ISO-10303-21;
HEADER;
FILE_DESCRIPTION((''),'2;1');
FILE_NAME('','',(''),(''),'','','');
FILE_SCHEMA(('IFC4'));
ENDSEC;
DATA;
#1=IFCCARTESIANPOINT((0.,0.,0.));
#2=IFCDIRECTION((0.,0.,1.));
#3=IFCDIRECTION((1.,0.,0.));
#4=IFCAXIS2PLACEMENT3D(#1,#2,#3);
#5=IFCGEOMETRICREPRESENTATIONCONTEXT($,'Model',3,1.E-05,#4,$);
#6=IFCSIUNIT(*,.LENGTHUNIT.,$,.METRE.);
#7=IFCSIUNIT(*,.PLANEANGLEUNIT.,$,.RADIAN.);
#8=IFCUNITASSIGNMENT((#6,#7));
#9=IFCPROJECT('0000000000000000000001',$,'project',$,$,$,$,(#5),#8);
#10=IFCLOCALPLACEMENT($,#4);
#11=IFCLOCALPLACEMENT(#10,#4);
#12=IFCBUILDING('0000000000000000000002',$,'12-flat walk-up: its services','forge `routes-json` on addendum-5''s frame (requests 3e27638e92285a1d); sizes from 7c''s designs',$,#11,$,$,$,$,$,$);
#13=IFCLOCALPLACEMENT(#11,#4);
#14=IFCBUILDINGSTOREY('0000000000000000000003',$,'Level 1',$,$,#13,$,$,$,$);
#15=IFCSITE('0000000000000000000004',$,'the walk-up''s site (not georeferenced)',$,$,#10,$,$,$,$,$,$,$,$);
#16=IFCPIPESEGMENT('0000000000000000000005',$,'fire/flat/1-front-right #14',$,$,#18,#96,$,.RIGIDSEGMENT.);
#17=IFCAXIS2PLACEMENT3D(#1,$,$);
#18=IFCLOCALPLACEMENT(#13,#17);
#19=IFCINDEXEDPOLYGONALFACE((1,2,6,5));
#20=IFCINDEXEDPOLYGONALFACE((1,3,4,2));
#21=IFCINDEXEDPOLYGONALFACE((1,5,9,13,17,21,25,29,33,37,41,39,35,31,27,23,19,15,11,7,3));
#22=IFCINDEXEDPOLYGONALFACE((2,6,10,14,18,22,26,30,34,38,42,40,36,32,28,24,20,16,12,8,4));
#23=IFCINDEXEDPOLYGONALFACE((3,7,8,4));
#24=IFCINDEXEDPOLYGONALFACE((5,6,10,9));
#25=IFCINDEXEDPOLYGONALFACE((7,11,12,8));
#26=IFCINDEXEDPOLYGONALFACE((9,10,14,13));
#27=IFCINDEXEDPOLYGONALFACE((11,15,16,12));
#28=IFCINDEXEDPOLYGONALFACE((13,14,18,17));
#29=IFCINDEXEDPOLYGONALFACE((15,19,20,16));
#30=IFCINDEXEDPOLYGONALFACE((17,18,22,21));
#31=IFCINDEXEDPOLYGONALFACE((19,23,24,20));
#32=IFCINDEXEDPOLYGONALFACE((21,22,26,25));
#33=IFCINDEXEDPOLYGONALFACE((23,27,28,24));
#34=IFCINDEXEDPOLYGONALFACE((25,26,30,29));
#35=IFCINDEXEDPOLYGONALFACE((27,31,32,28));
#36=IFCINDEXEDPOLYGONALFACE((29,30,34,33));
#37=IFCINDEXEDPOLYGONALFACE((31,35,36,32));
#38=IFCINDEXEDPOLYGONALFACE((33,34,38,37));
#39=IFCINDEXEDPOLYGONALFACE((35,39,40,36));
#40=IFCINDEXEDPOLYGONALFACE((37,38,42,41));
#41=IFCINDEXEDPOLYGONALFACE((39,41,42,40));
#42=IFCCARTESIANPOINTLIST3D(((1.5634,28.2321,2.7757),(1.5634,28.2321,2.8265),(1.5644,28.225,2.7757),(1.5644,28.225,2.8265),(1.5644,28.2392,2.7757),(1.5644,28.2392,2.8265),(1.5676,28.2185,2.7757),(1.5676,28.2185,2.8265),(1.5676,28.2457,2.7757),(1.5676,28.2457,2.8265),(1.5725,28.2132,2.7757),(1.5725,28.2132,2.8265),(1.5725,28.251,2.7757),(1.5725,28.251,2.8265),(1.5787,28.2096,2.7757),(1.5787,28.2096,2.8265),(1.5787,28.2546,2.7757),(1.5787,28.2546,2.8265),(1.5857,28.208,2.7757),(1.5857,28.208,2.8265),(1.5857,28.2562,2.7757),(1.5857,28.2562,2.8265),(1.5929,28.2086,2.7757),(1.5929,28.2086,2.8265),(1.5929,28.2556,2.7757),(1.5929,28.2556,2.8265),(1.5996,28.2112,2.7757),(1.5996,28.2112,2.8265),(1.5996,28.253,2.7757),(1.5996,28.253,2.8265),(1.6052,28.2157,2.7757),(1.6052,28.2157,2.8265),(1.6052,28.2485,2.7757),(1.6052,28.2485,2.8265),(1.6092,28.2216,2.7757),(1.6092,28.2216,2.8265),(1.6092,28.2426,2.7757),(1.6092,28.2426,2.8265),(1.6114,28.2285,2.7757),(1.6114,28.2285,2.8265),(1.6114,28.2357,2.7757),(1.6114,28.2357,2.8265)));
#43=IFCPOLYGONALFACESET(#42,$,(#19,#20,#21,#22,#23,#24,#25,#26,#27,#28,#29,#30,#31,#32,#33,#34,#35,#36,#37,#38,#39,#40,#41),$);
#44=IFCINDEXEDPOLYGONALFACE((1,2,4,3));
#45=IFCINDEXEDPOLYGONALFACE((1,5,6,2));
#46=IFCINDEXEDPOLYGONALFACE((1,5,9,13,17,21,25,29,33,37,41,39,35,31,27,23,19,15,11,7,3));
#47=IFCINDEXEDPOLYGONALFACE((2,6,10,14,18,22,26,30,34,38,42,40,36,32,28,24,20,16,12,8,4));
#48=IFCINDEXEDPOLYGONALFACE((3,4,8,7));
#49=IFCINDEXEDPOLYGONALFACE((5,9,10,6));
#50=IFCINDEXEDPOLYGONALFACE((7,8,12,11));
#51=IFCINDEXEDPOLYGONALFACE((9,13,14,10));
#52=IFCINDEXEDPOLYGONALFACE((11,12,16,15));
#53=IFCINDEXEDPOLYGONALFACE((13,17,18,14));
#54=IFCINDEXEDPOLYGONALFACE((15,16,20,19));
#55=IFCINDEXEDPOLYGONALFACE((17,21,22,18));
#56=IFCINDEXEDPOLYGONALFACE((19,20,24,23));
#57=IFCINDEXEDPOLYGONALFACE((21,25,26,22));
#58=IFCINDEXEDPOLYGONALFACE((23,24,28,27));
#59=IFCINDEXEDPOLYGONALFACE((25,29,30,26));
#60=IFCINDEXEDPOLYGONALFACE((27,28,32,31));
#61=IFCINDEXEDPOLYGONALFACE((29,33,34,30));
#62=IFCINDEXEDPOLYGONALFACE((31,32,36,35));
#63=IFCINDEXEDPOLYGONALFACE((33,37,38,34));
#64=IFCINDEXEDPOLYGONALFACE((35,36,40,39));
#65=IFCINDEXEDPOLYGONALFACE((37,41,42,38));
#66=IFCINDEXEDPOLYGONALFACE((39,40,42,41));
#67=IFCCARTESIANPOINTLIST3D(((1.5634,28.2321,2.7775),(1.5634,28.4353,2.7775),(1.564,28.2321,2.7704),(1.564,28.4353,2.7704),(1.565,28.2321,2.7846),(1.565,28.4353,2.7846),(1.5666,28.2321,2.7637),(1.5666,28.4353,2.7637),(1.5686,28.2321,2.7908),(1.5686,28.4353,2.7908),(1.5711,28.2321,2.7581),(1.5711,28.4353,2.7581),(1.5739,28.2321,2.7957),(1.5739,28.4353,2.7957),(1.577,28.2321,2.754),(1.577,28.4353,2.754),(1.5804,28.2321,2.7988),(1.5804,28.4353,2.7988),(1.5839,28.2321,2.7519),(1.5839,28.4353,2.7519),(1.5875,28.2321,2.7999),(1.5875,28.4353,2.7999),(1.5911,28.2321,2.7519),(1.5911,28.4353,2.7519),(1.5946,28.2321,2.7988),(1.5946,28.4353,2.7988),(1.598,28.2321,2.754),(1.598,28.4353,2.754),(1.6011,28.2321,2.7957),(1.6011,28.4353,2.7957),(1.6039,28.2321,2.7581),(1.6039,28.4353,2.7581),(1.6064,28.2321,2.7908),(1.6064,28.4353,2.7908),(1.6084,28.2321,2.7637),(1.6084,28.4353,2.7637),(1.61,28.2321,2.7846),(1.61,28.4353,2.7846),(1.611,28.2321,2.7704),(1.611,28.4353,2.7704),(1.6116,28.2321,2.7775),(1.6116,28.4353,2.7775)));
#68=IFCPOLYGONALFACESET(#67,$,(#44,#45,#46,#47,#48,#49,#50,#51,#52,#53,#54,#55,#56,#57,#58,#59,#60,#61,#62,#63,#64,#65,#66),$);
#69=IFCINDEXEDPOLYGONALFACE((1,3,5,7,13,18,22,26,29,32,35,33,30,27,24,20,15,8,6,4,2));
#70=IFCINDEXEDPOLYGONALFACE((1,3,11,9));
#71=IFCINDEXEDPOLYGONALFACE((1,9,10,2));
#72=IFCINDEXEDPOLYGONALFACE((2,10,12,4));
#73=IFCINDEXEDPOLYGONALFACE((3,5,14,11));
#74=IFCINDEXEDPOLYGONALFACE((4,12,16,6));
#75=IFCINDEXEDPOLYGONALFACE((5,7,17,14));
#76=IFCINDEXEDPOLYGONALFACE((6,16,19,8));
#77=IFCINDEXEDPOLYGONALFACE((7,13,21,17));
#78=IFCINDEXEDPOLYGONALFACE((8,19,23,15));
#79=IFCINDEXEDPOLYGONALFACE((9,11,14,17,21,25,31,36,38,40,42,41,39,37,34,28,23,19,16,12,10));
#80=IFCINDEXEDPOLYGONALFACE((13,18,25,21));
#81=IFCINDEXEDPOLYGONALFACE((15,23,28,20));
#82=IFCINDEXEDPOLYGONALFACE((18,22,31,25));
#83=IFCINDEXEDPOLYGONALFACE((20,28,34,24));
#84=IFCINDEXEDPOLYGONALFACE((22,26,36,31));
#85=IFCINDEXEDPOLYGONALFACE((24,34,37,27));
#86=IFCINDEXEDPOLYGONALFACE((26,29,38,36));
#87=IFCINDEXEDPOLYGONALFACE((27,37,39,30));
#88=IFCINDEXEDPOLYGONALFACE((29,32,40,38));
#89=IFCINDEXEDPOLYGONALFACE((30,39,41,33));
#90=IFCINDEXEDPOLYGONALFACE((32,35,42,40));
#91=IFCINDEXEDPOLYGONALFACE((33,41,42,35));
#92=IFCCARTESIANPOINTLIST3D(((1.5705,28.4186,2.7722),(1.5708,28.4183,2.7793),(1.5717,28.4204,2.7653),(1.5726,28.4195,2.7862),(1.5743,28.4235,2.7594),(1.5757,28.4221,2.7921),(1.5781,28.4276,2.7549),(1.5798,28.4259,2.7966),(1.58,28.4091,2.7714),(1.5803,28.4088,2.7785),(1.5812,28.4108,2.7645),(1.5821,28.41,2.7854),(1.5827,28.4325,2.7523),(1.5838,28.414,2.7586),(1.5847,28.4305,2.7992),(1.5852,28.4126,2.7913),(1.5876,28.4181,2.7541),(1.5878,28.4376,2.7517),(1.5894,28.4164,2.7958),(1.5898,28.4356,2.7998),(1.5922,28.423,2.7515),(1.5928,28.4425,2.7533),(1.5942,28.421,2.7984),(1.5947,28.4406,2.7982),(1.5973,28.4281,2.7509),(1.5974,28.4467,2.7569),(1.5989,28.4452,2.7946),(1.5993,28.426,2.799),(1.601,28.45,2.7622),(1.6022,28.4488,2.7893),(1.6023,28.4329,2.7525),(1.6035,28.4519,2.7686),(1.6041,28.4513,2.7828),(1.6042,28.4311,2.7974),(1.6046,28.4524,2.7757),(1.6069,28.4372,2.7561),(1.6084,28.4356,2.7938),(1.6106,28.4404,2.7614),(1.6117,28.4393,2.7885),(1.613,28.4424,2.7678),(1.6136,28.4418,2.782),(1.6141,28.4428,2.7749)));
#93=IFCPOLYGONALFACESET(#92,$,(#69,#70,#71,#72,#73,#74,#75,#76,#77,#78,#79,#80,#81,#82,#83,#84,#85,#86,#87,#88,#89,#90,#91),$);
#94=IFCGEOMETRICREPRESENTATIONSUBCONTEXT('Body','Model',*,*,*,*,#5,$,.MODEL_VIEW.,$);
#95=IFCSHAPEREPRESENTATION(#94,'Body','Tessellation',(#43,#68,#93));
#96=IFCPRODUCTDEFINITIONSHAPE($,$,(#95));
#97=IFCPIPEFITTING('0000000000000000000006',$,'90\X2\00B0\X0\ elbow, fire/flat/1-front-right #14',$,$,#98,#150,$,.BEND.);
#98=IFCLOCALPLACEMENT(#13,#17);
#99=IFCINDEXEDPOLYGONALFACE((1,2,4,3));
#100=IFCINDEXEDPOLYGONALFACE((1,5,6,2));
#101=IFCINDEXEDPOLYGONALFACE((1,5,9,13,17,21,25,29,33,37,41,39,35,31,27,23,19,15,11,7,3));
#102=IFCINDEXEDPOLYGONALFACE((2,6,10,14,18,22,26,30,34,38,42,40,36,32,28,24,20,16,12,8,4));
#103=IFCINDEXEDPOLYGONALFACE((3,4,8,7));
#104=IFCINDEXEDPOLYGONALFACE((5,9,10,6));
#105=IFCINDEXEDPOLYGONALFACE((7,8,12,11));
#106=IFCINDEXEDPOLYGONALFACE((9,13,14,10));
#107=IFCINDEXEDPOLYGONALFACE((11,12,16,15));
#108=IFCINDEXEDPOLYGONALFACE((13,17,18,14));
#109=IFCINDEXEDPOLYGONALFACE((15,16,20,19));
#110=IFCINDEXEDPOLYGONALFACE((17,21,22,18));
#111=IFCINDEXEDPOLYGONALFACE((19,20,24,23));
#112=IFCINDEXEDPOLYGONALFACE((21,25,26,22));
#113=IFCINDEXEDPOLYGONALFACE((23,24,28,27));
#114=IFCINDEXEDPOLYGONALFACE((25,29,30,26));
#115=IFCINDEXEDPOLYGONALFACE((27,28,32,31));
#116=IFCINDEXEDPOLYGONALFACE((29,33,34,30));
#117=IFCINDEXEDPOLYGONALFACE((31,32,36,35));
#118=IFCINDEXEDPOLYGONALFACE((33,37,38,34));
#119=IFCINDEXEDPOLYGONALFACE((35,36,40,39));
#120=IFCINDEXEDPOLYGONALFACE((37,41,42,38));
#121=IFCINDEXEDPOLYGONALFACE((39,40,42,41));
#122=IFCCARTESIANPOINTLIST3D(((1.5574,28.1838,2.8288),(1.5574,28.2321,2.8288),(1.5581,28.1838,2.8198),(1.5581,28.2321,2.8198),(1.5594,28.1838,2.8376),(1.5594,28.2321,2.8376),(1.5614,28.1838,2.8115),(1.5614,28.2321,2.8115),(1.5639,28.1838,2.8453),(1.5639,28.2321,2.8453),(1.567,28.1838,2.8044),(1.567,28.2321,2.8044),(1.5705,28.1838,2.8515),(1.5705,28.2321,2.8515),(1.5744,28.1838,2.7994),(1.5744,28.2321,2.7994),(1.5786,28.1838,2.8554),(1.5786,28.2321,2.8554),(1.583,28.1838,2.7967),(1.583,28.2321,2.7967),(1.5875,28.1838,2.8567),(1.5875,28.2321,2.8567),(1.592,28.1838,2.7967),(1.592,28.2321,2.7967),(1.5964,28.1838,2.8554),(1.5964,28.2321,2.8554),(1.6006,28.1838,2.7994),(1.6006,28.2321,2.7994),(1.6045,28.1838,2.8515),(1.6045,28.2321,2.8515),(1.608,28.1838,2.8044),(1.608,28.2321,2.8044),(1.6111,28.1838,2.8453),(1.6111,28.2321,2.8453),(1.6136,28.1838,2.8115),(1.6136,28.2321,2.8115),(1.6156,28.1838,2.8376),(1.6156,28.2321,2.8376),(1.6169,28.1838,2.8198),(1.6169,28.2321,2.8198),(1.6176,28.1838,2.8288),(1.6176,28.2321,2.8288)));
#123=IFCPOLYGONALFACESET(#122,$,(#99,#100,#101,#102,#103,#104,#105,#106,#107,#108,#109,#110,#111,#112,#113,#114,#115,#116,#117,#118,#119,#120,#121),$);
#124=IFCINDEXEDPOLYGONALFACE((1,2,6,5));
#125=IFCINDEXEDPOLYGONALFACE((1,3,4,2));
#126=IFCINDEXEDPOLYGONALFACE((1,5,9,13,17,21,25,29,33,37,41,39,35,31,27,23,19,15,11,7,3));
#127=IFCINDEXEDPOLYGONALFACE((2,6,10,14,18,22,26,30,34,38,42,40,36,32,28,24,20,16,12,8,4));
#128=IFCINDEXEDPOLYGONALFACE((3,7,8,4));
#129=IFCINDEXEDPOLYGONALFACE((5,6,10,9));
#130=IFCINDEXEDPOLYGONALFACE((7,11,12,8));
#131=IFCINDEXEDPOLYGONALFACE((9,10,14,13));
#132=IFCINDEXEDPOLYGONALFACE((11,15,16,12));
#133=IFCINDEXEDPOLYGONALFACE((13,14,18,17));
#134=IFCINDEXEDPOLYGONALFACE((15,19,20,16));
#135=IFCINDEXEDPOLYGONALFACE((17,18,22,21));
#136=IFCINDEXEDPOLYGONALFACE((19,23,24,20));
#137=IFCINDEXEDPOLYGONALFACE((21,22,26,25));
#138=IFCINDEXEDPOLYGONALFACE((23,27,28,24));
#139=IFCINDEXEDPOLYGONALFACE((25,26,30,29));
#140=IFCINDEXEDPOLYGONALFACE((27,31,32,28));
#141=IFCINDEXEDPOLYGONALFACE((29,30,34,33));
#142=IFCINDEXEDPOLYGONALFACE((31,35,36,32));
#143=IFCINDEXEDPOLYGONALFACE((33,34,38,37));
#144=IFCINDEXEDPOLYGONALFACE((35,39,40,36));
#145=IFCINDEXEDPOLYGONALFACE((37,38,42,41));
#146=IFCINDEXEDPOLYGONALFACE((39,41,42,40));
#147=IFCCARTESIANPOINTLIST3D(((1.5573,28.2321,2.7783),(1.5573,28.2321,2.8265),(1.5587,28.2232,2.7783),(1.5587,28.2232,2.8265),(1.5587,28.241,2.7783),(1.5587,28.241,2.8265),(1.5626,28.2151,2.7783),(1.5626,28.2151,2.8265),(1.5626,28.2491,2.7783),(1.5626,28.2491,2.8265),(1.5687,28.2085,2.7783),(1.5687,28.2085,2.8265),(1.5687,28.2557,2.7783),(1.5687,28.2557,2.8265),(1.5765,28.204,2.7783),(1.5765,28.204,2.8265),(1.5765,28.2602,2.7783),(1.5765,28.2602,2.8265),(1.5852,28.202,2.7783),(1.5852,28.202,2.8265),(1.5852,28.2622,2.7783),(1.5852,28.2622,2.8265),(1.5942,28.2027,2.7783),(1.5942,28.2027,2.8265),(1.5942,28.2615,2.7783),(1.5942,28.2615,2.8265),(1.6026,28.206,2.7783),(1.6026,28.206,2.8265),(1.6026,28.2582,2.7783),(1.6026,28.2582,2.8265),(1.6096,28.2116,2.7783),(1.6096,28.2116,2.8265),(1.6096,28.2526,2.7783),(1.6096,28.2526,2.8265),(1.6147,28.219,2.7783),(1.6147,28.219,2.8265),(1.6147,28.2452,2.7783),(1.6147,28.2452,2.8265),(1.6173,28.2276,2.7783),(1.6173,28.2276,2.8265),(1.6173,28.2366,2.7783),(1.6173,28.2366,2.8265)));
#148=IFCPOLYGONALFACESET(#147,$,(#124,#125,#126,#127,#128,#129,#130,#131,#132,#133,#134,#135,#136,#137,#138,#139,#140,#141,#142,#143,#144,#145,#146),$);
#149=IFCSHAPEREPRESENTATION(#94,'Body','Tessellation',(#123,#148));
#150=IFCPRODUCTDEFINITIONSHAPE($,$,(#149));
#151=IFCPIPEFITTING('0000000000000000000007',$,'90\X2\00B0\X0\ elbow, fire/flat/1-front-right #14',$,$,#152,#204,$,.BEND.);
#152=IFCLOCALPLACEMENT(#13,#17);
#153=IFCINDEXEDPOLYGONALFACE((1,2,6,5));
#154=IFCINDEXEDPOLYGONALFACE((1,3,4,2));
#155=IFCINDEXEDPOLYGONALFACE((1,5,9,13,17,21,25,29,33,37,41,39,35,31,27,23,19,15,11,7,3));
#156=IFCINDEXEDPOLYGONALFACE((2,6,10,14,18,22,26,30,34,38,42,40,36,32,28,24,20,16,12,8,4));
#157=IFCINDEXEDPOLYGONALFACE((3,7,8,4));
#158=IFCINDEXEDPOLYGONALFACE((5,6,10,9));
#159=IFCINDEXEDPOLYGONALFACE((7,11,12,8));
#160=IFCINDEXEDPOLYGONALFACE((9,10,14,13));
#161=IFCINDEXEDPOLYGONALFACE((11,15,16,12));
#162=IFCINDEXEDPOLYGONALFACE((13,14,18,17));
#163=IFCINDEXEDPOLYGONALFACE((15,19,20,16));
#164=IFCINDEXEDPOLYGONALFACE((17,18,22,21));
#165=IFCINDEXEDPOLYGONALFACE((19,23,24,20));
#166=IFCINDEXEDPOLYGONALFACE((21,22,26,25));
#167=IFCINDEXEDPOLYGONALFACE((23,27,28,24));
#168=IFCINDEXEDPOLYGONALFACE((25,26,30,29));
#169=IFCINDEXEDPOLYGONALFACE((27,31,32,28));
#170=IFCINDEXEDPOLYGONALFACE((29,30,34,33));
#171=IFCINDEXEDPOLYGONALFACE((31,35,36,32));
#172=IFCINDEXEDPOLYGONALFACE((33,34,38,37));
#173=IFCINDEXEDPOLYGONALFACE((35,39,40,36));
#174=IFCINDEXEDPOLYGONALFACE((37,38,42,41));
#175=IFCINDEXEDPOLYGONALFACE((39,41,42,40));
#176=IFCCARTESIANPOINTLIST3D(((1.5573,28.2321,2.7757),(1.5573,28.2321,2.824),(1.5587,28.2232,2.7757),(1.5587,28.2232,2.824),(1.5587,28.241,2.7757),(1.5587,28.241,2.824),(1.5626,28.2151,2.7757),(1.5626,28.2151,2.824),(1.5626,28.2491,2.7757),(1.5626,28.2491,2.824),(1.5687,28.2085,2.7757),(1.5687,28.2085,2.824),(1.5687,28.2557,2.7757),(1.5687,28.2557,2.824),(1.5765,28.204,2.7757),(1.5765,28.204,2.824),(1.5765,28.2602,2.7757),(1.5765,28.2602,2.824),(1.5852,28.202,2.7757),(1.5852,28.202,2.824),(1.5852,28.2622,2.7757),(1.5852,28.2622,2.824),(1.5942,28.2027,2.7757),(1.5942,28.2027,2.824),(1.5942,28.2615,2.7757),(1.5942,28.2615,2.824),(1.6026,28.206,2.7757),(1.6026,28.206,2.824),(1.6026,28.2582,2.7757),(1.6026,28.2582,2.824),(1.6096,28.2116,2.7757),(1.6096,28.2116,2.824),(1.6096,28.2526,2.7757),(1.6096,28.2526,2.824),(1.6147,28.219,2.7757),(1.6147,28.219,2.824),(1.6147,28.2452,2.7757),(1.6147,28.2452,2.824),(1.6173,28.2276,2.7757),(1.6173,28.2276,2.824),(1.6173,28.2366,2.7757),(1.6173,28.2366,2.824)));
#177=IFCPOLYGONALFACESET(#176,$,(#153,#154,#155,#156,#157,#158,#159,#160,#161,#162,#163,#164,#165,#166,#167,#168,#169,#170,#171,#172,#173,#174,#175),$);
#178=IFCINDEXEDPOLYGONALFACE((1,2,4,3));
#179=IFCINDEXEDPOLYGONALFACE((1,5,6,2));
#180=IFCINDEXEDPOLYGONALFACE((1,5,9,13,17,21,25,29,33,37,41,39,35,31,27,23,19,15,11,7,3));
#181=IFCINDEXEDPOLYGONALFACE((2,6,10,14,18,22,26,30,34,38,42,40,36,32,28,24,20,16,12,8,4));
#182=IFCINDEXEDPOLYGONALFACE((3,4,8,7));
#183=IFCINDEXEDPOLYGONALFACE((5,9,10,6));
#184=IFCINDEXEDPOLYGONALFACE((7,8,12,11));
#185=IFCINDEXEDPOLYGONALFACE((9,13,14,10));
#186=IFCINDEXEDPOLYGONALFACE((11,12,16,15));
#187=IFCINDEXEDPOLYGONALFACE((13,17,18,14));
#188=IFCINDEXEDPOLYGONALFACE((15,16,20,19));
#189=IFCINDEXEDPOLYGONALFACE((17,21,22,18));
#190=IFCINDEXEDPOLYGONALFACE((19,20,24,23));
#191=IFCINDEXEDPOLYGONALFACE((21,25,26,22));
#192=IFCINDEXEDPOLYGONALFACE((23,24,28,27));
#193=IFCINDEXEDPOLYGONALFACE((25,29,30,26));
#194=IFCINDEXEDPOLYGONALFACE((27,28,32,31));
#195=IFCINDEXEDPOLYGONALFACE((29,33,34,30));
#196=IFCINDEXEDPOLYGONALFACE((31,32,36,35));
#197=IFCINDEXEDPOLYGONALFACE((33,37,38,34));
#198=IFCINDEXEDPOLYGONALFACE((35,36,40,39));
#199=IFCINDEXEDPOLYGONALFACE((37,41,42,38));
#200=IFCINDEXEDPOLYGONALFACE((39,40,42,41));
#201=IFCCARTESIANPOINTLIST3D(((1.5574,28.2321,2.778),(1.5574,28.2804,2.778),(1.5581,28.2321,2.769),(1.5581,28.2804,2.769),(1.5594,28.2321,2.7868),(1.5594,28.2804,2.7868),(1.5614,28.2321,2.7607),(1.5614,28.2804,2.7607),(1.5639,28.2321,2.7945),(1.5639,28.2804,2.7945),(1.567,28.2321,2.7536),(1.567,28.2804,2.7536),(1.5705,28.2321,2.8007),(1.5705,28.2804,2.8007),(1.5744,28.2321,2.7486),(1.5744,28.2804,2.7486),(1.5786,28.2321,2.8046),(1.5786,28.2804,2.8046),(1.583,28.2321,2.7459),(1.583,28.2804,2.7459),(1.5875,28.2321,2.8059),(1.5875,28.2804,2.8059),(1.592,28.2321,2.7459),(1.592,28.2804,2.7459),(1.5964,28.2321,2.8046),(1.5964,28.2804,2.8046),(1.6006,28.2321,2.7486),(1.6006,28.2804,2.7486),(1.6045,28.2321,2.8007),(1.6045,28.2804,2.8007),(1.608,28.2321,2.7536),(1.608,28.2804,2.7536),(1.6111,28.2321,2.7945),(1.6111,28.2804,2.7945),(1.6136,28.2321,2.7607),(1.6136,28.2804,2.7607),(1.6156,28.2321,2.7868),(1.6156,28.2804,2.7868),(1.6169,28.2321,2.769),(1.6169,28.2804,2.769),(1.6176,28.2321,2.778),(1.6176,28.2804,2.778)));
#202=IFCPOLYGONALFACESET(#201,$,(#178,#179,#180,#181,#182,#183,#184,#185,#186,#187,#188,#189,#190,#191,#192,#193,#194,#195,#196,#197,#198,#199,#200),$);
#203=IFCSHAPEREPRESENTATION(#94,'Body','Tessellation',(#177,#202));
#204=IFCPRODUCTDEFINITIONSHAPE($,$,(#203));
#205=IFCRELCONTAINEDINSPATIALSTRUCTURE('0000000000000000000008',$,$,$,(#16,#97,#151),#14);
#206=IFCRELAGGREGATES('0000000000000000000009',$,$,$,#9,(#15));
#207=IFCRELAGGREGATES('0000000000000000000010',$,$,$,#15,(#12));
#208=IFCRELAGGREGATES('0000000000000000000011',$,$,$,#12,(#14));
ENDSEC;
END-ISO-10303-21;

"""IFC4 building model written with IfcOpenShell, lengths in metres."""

from ifc_helpers import new_model, entity, si_unit, frame, origin_with_axes, place, context, subcontext, project, spatial, element, save


model = new_model("IFC4")

# Units and contexts
model_context = context("Model", 3, precision=1e-05, world=origin_with_axes())
body_context = subcontext(model_context, "Body", "Model", "MODEL_VIEW")
ifc_project = project(units=[si_unit("LENGTHUNIT", "METRE"), si_unit("PLANEANGLEUNIT", "RADIAN")], contexts=[model_context])

# Site, building, storey
site_placement = place(None, origin_with_axes())
site = spatial("IfcSite", under=ifc_project, at=site_placement, Name="the walk-up's site (not georeferenced)")
building_placement = place(site_placement, origin_with_axes())
building = spatial("IfcBuilding", under=site, at=building_placement, Name="12-flat walk-up: its services", Description="forge `routes-json` on addendum-5's frame (requests 3e27638e92285a1d); sizes from 7c's designs")
storey_placement = place(building_placement, origin_with_axes())
storey = spatial("IfcBuildingStorey", under=building, at=storey_placement, Name="Level 1")

# Pipe segment
pipe_segment_1_placement = place(storey_placement, frame((1.5875, 28.2321, 2.8265), z_axis=(0.0, 0.0, 1.0), x_axis=(1.0, 0.0, 0.0)))
element("IfcPipeSegment", 1, at=pipe_segment_1_placement, inside=storey, Name="fire/flat/1-front-right #14", PredefinedType="RIGIDSEGMENT", context=body_context, shape_type="AdvancedSweptSolid", body=[
    entity("IfcSweptDiskSolid", entity("IfcPolyline", [entity("IfcCartesianPoint", [0.0, 0.0, 0.0]), entity("IfcCartesianPoint", [0.0, 0.0, -0.0508])]), 0.0241),
    entity("IfcSweptDiskSolid", entity("IfcPolyline", [entity("IfcCartesianPoint", [0.0, 0.0, -0.0508]), entity("IfcCartesianPoint", [0.0, 0.2032, -0.0508])]), 0.0241),
    entity("IfcSweptDiskSolid", entity("IfcPolyline", [entity("IfcCartesianPoint", [0.0, 0.2032, -0.0508]), entity("IfcCartesianPoint", [0.0095, 0.1937, -0.0516])]), 0.0241),
])

# Pipe fittings
pipe_fitting_1_placement = place(storey_placement, frame((1.5875, 28.1838, 2.8265), z_axis=(0.0, 0.0, 1.0), x_axis=(1.0, 0.0, 0.0)))
element("IfcPipeFitting", 2, at=pipe_fitting_1_placement, inside=storey, Name="90° elbow, fire/flat/1-front-right #14", PredefinedType="BEND", context=body_context, shape_type="AdvancedSweptSolid", body=[
    entity("IfcSweptDiskSolid", entity("IfcPolyline", [entity("IfcCartesianPoint", [0.0, 0.0, 0.0]), entity("IfcCartesianPoint", [0.0, 0.0483, 0.0])]), 0.0302),
    entity("IfcSweptDiskSolid", entity("IfcPolyline", [entity("IfcCartesianPoint", [0.0, 0.0483, 0.0]), entity("IfcCartesianPoint", [0.0, 0.0483, -0.0483])]), 0.0302),
])
pipe_fitting_2_placement = place(storey_placement, frame((1.5875, 28.2321, 2.824), z_axis=(0.0, 0.0, 1.0), x_axis=(1.0, 0.0, 0.0)))
element("IfcPipeFitting", 3, at=pipe_fitting_2_placement, inside=storey, Name="90° elbow, fire/flat/1-front-right #14", PredefinedType="BEND", context=body_context, shape_type="AdvancedSweptSolid", body=[
    entity("IfcSweptDiskSolid", entity("IfcPolyline", [entity("IfcCartesianPoint", [0.0, 0.0, 0.0]), entity("IfcCartesianPoint", [0.0, 0.0, -0.0483])]), 0.0302),
    entity("IfcSweptDiskSolid", entity("IfcPolyline", [entity("IfcCartesianPoint", [0.0, 0.0, -0.0483]), entity("IfcCartesianPoint", [0.0, 0.0483, -0.0483])]), 0.0302),
])

save(model, "model.ifc")
